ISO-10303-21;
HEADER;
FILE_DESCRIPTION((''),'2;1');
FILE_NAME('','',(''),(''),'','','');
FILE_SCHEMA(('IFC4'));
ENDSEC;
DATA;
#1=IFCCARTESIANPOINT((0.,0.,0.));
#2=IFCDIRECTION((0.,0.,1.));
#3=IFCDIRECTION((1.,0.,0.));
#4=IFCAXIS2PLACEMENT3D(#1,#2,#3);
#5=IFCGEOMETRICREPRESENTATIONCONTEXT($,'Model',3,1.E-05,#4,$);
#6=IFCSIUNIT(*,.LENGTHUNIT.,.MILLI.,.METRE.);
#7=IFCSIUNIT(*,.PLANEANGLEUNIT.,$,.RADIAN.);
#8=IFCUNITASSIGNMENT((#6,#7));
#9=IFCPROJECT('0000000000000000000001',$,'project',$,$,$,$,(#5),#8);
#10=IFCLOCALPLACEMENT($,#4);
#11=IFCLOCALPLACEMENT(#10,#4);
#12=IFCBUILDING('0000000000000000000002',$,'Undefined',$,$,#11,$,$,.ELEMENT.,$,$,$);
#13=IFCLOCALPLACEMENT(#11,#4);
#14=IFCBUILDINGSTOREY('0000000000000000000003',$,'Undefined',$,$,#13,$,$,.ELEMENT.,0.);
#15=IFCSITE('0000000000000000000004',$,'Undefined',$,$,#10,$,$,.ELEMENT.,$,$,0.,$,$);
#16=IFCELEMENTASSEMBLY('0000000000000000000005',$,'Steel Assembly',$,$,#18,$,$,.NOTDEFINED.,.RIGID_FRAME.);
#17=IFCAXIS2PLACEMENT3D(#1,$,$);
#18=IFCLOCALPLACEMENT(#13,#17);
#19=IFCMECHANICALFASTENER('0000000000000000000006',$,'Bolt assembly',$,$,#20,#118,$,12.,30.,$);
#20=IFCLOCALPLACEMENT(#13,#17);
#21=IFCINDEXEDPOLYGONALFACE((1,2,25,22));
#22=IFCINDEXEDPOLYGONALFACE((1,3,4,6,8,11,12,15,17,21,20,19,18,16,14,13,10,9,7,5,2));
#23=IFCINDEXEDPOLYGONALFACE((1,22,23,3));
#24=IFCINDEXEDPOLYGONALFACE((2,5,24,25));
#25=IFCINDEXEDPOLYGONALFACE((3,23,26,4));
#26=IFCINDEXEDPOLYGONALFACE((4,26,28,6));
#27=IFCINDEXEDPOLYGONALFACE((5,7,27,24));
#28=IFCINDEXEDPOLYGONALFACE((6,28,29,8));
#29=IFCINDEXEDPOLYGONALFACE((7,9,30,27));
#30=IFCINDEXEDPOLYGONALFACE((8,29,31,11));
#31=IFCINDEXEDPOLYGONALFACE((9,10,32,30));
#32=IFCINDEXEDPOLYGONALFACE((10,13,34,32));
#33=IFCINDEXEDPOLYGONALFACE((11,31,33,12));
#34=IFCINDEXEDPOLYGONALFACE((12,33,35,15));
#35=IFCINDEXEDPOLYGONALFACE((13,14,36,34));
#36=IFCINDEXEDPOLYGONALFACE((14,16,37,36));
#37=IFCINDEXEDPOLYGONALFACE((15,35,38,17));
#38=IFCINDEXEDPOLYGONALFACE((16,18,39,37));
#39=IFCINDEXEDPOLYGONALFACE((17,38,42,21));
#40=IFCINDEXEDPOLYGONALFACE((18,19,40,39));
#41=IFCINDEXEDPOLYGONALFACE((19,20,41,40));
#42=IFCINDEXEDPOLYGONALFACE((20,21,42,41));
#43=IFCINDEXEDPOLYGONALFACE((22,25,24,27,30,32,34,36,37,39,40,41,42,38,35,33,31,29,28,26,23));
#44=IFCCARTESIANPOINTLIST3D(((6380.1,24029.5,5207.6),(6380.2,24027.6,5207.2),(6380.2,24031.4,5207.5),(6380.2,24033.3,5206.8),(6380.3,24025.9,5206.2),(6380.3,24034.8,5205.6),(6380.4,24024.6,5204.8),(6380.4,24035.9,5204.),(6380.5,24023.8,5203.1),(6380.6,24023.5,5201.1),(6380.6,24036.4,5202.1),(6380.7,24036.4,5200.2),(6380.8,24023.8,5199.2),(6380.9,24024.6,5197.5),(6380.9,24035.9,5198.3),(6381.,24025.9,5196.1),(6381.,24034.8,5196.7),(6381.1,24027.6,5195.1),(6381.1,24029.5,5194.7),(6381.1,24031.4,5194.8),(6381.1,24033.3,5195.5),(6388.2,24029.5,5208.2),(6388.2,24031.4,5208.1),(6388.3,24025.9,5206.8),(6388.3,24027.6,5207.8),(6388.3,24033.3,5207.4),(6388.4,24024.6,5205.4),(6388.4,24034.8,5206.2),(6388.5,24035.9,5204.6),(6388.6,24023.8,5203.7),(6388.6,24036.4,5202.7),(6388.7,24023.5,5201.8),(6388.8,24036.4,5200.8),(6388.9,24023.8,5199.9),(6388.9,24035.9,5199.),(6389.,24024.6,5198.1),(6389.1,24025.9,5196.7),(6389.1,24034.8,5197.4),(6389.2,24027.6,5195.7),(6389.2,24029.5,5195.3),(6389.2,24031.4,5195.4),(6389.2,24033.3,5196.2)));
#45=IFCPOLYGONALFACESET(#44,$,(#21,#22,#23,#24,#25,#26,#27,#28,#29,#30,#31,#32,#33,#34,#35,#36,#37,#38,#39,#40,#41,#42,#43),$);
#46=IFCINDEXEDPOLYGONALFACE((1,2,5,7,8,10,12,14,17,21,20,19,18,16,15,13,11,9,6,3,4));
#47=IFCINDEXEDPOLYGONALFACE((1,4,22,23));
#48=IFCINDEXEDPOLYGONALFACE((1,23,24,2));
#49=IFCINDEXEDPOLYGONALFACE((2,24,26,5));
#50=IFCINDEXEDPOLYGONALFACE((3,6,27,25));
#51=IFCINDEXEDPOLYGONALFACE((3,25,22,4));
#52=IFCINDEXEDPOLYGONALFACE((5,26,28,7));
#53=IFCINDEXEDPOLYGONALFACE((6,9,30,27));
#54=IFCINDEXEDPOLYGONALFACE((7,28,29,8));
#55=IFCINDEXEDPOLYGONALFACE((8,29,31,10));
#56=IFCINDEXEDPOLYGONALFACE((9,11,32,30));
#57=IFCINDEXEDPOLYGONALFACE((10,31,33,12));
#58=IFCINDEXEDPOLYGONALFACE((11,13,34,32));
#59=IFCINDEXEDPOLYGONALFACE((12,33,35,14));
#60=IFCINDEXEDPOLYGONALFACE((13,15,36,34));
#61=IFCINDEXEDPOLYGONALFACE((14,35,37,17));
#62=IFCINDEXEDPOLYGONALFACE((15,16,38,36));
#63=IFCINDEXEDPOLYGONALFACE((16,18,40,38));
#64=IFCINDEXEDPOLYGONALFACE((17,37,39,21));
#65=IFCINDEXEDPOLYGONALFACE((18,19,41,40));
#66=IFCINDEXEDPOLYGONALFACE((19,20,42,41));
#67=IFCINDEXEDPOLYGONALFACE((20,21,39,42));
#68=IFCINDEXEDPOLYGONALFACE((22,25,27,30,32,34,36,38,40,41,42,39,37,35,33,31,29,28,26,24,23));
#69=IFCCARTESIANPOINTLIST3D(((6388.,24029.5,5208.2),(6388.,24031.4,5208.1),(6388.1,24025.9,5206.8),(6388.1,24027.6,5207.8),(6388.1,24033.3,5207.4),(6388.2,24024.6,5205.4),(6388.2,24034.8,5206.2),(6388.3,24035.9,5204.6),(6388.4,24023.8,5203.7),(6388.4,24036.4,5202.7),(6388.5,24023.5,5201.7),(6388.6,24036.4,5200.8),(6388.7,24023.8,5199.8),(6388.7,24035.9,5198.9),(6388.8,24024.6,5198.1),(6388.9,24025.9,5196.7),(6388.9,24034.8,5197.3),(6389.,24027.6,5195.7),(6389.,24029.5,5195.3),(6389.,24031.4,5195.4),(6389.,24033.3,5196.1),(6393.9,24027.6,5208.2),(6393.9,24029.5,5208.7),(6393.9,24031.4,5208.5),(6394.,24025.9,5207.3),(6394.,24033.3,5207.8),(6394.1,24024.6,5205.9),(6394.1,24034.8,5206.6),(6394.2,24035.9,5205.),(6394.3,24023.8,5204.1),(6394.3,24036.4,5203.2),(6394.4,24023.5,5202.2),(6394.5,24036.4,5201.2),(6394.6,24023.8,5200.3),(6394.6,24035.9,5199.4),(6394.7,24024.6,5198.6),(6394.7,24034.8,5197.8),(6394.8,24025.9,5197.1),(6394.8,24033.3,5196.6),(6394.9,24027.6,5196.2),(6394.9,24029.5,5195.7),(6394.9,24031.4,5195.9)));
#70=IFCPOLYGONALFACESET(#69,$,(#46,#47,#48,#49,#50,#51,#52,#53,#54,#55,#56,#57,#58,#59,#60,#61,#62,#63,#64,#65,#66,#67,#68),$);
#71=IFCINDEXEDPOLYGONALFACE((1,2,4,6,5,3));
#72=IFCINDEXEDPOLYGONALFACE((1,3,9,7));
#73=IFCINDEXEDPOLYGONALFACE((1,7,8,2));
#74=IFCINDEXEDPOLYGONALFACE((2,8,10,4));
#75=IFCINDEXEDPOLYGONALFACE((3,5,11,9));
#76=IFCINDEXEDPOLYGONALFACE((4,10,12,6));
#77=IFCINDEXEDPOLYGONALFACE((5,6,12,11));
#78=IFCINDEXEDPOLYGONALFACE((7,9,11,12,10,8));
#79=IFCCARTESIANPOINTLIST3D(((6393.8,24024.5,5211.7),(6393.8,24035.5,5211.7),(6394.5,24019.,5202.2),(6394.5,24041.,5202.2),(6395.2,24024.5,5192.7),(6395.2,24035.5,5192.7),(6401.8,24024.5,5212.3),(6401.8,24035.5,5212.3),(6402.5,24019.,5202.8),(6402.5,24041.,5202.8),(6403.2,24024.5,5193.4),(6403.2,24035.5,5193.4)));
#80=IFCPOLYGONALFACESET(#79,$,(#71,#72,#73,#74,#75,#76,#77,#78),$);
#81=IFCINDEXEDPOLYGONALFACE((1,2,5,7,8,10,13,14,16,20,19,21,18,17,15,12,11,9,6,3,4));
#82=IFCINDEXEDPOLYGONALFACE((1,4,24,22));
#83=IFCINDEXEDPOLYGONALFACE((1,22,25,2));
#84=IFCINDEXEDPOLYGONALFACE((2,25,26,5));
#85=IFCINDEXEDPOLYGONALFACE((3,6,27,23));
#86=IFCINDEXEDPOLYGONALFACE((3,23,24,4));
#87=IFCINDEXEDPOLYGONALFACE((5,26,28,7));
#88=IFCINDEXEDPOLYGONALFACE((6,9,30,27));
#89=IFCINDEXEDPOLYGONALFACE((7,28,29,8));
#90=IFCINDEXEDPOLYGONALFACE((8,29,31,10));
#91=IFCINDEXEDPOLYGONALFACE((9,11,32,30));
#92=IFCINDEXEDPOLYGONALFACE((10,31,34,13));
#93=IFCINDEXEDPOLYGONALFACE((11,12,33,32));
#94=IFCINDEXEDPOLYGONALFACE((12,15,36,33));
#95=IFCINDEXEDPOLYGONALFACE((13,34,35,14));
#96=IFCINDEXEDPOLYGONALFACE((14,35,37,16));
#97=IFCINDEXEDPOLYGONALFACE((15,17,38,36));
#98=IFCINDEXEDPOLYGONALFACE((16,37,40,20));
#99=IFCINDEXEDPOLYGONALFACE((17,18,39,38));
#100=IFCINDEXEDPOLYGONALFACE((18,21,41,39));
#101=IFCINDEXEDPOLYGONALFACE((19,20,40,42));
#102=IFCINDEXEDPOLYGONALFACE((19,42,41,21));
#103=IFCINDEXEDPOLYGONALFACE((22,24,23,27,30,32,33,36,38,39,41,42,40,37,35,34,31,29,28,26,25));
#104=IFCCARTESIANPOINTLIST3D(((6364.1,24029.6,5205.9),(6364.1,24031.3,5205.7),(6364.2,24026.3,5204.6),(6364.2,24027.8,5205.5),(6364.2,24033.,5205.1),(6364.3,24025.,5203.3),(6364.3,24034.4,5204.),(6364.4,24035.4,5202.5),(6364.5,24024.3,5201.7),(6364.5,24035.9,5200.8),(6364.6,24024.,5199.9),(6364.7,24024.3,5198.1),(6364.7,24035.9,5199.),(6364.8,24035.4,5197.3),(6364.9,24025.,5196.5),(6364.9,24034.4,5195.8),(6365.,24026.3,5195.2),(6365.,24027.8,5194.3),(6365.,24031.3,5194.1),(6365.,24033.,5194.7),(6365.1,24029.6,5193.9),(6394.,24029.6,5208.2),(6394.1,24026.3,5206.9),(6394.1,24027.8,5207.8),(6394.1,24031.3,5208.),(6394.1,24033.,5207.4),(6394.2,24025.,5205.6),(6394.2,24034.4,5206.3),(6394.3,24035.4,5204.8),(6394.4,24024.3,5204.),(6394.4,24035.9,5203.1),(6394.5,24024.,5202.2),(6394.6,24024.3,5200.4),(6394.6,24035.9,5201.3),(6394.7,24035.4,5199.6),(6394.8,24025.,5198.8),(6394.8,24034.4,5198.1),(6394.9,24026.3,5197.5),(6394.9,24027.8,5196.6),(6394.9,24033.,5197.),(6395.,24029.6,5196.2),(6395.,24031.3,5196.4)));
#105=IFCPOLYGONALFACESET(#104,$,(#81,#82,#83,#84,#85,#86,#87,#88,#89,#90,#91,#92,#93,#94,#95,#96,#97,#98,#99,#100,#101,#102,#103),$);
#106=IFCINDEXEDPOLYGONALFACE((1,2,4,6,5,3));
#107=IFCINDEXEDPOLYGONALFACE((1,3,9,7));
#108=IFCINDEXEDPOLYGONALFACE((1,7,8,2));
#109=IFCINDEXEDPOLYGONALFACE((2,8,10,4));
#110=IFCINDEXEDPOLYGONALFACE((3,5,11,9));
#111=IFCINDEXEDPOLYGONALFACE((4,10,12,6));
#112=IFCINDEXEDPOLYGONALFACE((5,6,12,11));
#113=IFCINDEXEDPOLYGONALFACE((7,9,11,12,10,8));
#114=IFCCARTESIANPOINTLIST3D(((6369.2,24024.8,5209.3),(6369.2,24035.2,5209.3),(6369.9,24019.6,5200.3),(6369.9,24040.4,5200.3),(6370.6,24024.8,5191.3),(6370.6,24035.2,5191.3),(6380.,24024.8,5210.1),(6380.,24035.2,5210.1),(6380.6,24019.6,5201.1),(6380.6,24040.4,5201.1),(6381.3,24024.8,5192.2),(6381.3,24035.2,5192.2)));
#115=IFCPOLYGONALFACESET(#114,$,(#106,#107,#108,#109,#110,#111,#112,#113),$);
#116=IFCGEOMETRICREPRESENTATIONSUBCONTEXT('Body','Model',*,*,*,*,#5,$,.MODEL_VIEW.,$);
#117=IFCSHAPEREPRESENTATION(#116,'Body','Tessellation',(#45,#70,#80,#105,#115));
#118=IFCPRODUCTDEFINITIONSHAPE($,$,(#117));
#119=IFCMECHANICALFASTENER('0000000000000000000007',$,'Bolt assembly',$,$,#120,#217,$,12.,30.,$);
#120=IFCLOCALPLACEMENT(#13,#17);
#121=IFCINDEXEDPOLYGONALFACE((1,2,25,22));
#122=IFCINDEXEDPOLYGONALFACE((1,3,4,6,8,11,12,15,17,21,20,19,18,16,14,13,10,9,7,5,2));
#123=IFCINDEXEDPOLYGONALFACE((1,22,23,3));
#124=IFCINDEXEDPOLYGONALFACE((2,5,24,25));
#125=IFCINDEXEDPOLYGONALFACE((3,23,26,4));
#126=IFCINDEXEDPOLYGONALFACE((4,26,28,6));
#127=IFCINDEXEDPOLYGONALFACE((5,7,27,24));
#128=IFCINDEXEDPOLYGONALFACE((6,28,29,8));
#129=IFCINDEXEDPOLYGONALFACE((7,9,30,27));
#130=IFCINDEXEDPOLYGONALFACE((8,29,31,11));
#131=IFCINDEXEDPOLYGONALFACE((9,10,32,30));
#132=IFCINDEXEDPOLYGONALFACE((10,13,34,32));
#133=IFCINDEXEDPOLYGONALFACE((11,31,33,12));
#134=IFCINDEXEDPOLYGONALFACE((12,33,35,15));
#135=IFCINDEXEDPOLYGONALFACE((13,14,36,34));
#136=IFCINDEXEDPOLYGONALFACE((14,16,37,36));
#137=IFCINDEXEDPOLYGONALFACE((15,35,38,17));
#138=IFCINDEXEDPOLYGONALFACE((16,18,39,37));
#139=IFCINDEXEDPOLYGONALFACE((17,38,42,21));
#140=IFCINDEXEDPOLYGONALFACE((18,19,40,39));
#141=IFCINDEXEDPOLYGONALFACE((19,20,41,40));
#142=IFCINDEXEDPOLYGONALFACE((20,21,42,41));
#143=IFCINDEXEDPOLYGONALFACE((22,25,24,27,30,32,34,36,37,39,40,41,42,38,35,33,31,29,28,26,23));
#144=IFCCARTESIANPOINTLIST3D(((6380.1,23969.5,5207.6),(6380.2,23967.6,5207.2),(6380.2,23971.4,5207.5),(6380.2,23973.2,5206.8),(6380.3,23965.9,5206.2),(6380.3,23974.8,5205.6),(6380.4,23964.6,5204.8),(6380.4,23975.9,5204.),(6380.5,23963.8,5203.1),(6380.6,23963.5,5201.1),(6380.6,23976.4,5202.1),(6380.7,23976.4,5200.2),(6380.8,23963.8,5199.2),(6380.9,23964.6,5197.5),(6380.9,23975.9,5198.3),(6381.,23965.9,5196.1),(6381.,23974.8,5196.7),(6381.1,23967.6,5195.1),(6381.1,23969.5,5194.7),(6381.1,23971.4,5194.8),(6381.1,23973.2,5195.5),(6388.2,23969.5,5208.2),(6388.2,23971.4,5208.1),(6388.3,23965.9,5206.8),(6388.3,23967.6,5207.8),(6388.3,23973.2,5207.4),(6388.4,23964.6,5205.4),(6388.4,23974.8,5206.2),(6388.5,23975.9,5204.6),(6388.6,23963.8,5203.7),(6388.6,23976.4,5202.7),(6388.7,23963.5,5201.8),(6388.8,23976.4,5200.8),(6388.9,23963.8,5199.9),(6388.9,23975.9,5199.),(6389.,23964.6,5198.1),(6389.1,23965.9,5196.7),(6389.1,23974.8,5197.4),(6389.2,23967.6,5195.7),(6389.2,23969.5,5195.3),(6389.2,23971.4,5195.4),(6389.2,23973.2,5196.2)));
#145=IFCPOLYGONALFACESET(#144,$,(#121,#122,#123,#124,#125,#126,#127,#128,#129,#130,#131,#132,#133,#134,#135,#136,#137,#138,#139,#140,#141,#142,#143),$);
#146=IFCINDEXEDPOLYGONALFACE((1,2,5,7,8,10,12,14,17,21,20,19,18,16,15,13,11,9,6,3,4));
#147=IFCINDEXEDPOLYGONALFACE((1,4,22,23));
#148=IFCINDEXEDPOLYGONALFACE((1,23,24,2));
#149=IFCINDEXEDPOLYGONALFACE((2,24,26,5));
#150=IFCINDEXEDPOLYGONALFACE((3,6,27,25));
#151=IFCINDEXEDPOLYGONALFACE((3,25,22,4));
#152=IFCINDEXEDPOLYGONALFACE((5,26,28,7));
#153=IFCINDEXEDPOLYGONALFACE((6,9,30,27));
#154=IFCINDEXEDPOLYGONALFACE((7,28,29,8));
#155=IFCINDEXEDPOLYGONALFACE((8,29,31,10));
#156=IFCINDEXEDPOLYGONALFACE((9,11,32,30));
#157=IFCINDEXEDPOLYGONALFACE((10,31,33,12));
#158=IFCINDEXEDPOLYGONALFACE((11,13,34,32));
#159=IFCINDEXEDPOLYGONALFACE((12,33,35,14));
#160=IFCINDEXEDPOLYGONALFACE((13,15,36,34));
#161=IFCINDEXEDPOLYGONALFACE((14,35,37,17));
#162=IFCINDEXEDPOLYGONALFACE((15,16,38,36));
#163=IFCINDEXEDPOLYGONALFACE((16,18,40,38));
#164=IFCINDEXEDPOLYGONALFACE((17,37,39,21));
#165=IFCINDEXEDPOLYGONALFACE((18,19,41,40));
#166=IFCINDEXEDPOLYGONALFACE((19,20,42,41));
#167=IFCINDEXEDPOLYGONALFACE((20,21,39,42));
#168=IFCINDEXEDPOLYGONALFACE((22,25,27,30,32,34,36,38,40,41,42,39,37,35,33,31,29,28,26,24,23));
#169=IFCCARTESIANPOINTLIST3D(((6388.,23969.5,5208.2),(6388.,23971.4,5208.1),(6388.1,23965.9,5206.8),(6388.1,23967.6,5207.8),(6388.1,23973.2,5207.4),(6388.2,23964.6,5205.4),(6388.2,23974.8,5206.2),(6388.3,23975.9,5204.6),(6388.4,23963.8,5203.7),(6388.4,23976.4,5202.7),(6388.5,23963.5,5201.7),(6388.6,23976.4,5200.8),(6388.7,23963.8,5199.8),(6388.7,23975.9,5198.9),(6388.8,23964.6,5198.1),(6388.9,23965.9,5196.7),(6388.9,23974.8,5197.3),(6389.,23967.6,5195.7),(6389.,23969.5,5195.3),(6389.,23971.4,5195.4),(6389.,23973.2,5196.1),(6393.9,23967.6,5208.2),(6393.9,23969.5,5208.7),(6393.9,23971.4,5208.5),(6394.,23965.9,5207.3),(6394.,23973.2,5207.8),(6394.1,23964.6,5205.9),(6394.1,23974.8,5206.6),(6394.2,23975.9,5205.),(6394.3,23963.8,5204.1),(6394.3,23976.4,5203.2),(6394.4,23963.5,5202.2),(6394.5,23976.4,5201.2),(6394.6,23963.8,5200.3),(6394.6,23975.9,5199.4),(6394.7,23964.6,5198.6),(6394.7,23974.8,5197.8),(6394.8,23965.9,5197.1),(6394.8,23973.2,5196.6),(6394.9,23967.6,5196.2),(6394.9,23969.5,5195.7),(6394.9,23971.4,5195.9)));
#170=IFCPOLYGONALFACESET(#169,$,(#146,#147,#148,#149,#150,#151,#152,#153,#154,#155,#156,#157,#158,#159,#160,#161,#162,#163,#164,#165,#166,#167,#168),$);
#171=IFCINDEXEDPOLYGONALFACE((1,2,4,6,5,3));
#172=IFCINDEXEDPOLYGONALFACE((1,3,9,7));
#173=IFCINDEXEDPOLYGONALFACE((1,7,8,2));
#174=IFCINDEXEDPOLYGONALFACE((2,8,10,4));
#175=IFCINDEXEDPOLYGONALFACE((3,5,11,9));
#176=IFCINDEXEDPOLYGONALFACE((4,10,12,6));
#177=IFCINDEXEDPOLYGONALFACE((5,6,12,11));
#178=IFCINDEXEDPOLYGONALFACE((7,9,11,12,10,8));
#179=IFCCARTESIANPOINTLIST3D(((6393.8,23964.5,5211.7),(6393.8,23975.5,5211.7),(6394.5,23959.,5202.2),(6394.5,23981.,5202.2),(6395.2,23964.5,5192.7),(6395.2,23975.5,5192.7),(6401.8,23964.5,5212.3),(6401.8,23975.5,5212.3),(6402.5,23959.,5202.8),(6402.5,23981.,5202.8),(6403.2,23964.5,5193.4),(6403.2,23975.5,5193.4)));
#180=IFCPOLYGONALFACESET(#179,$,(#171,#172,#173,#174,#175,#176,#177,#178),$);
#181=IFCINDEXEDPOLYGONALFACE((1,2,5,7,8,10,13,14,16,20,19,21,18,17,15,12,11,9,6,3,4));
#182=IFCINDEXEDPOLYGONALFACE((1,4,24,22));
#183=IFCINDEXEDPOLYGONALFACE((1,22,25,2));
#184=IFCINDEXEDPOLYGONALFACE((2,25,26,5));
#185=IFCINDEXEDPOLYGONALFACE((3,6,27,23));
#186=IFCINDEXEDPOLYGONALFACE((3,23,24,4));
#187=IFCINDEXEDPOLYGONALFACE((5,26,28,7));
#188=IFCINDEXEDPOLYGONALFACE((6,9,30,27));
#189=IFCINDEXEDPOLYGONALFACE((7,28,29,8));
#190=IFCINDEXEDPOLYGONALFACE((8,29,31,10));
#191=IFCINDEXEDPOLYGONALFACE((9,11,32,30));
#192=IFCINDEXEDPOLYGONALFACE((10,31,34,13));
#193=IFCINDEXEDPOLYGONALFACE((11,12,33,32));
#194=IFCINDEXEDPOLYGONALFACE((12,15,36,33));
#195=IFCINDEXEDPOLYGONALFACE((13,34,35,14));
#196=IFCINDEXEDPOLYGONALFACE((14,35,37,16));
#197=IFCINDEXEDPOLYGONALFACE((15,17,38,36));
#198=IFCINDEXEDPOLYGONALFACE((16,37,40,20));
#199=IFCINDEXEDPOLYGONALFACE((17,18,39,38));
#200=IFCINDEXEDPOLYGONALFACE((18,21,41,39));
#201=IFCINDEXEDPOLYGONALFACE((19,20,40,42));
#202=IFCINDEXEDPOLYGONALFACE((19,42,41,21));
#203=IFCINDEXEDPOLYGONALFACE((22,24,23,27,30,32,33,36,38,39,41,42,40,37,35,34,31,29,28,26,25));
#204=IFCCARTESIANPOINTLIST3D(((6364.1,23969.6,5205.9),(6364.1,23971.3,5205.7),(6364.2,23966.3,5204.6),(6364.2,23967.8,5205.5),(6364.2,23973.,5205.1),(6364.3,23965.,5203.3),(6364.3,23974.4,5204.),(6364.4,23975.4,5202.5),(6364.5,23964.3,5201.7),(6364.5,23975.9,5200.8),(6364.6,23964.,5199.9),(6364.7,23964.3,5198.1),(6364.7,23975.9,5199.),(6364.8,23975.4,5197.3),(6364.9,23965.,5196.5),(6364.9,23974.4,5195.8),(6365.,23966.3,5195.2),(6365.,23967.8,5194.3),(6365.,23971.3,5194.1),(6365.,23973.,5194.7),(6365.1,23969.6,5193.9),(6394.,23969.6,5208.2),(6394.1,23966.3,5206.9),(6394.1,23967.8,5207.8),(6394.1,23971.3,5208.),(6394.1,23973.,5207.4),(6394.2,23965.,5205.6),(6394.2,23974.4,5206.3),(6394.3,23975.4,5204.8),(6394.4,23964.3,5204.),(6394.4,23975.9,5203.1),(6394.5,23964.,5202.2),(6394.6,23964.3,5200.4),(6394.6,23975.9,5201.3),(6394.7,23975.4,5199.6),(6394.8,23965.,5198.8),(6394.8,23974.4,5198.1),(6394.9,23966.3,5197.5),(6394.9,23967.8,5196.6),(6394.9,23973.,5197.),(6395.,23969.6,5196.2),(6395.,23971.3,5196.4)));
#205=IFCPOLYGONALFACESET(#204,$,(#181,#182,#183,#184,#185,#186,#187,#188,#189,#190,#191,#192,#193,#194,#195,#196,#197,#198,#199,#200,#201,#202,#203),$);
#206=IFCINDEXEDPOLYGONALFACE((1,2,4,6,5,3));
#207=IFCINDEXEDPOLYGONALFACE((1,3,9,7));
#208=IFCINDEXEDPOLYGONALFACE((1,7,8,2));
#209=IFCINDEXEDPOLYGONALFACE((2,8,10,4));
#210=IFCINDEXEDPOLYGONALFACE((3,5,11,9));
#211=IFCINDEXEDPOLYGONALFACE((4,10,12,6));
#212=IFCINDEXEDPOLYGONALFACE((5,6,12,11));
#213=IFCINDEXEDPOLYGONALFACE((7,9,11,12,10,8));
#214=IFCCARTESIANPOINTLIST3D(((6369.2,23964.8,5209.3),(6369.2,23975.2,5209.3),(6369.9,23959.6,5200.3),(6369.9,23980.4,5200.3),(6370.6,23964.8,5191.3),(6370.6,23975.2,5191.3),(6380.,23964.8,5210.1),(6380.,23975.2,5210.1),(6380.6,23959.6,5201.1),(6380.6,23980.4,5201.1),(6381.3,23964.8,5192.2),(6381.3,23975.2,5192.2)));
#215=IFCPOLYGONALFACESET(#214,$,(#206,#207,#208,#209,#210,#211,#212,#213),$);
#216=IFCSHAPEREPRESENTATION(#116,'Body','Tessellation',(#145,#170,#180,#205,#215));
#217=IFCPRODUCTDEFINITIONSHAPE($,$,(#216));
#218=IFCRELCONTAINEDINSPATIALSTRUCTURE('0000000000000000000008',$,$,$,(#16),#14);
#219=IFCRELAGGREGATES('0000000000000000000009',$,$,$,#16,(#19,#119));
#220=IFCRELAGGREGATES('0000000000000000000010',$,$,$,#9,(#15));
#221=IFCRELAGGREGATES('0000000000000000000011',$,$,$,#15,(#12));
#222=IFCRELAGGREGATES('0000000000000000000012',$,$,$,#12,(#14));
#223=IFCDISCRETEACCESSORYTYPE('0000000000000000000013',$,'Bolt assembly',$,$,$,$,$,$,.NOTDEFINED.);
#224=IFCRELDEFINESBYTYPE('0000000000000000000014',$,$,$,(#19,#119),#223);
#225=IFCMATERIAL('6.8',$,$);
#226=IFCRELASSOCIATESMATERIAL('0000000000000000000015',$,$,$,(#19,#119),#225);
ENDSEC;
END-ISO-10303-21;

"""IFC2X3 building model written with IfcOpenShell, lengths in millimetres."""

from ifc_helpers import new_model, si_unit, frame, origin_with_axes, origin_2d_with_axis, place, context, subcontext, project, spatial, polyline, circle, outline, extrude, source, transform, mapped, material, type_object, element, aggregate, save


model = new_model("IFC2X3")

# Units and contexts
model_context = context("Model", 3, precision=1e-05, world=origin_with_axes())
body_context = subcontext(model_context, "Body", "Model", "MODEL_VIEW")
ifc_project = project(units=[si_unit("LENGTHUNIT", "METRE", prefix="MILLI"), si_unit("PLANEANGLEUNIT", "RADIAN")], contexts=[model_context])

# Site, building, storey
site_placement = place(None, origin_with_axes())
site = spatial("IfcSite", under=ifc_project, at=site_placement, Name="Undefined", CompositionType="ELEMENT", RefElevation=0.0)
building_placement = place(site_placement, origin_with_axes())
building = spatial("IfcBuilding", under=site, at=building_placement, Name="Undefined", CompositionType="ELEMENT")
storey_placement = place(building_placement, origin_with_axes())
storey = spatial("IfcBuildingStorey", under=building, at=storey_placement, Name="Undefined", CompositionType="ELEMENT", Elevation=0.0)

# Element assembly
assembly_1_placement = place(storey_placement, origin_with_axes())
assembly_1 = element("IfcElementAssembly", 1, at=assembly_1_placement, inside=storey, Name="Steel Assembly", AssemblyPlace="NOTDEFINED", PredefinedType="RIGID_FRAME")

# Mechanical fasteners
ifc_material_1 = material(Name="6.8")
discrete_accessory_type_1 = type_object("IfcDiscreteAccessoryType", Name="Bolt assembly")
shared_shape_1 = source(origin_with_axes(), body_context, "Body", "SweptSolid", [
    extrude(circle(Radius=6.5, at=origin_2d_with_axis()), frame((0.0, 2.9, 0.0), z_axis=(0.0, 1.0, 0.0), x_axis=(1.0, 0.0, 0.0)), (0.0, 0.0, 1.0), 8.1),
    extrude(circle(Radius=6.5, at=origin_2d_with_axis()), frame((0.0, -2.9, 0.0), z_axis=(0.0, 1.0, 0.0), x_axis=(1.0, 0.0, 0.0)), (0.0, 0.0, 1.0), 5.9),
    extrude(outline(polyline([(11.0, 0.0), (5.5, 9.5), (-5.5, 9.5), (-11.0, 0.0), (-5.5, -9.5), (5.5, -9.5), (11.0, 0.0)])), frame((0.0, -11.0, 0.0), z_axis=(0.0, 1.0, 0.0), x_axis=(1.0, 0.0, 0.0)), (0.0, 0.0, 1.0), 8.0),
    extrude(circle(Radius=6.0, at=origin_2d_with_axis()), frame((0.0, -3.0, 0.0), z_axis=(0.0, 1.0, 0.0), x_axis=(1.0, 0.0, 0.0)), (0.0, 0.0, 1.0), 30.0),
    extrude(outline(polyline([(10.4, 0.0), (5.2, 9.0), (-5.2, 9.0), (-10.4, 0.0), (-5.2, -9.0), (5.2, -9.0), (10.4, 0.0)])), frame((0.0, 11.0, 0.0), z_axis=(0.0, 1.0, 0.0), x_axis=(1.0, 0.0, 0.0)), (0.0, 0.0, 1.0), 10.8),
])
mechanical_fastener_1_placement = place(assembly_1_placement, frame((6391.6, 24030.0, 5202.0), z_axis=(0.076696, 0.0, -0.997054), x_axis=(0.0, -1.0, 0.0)))
mechanical_fastener_1 = element("IfcMechanicalFastener", 2, at=mechanical_fastener_1_placement, type_object=discrete_accessory_type_1, material=ifc_material_1, Name="Bolt assembly", NominalDiameter=12.0, NominalLength=30.0, context=body_context, shape_type="MappedRepresentation", body=[
    mapped(shared_shape_1, transform((0.0, 0.0, 0.0))),
])
mechanical_fastener_2_placement = place(assembly_1_placement, frame((6391.6, 23970.0, 5202.0), z_axis=(0.076696, 0.0, -0.997054), x_axis=(0.0, -1.0, 0.0)))
mechanical_fastener_2 = element("IfcMechanicalFastener", 3, at=mechanical_fastener_2_placement, type_object=discrete_accessory_type_1, material=ifc_material_1, Name="Bolt assembly", NominalDiameter=12.0, NominalLength=30.0, context=body_context, shape_type="MappedRepresentation", body=[
    mapped(shared_shape_1, transform((0.0, 0.0, 0.0))),
])

aggregate(assembly_1, [mechanical_fastener_1, mechanical_fastener_2])

save(model, "model.ifc")
